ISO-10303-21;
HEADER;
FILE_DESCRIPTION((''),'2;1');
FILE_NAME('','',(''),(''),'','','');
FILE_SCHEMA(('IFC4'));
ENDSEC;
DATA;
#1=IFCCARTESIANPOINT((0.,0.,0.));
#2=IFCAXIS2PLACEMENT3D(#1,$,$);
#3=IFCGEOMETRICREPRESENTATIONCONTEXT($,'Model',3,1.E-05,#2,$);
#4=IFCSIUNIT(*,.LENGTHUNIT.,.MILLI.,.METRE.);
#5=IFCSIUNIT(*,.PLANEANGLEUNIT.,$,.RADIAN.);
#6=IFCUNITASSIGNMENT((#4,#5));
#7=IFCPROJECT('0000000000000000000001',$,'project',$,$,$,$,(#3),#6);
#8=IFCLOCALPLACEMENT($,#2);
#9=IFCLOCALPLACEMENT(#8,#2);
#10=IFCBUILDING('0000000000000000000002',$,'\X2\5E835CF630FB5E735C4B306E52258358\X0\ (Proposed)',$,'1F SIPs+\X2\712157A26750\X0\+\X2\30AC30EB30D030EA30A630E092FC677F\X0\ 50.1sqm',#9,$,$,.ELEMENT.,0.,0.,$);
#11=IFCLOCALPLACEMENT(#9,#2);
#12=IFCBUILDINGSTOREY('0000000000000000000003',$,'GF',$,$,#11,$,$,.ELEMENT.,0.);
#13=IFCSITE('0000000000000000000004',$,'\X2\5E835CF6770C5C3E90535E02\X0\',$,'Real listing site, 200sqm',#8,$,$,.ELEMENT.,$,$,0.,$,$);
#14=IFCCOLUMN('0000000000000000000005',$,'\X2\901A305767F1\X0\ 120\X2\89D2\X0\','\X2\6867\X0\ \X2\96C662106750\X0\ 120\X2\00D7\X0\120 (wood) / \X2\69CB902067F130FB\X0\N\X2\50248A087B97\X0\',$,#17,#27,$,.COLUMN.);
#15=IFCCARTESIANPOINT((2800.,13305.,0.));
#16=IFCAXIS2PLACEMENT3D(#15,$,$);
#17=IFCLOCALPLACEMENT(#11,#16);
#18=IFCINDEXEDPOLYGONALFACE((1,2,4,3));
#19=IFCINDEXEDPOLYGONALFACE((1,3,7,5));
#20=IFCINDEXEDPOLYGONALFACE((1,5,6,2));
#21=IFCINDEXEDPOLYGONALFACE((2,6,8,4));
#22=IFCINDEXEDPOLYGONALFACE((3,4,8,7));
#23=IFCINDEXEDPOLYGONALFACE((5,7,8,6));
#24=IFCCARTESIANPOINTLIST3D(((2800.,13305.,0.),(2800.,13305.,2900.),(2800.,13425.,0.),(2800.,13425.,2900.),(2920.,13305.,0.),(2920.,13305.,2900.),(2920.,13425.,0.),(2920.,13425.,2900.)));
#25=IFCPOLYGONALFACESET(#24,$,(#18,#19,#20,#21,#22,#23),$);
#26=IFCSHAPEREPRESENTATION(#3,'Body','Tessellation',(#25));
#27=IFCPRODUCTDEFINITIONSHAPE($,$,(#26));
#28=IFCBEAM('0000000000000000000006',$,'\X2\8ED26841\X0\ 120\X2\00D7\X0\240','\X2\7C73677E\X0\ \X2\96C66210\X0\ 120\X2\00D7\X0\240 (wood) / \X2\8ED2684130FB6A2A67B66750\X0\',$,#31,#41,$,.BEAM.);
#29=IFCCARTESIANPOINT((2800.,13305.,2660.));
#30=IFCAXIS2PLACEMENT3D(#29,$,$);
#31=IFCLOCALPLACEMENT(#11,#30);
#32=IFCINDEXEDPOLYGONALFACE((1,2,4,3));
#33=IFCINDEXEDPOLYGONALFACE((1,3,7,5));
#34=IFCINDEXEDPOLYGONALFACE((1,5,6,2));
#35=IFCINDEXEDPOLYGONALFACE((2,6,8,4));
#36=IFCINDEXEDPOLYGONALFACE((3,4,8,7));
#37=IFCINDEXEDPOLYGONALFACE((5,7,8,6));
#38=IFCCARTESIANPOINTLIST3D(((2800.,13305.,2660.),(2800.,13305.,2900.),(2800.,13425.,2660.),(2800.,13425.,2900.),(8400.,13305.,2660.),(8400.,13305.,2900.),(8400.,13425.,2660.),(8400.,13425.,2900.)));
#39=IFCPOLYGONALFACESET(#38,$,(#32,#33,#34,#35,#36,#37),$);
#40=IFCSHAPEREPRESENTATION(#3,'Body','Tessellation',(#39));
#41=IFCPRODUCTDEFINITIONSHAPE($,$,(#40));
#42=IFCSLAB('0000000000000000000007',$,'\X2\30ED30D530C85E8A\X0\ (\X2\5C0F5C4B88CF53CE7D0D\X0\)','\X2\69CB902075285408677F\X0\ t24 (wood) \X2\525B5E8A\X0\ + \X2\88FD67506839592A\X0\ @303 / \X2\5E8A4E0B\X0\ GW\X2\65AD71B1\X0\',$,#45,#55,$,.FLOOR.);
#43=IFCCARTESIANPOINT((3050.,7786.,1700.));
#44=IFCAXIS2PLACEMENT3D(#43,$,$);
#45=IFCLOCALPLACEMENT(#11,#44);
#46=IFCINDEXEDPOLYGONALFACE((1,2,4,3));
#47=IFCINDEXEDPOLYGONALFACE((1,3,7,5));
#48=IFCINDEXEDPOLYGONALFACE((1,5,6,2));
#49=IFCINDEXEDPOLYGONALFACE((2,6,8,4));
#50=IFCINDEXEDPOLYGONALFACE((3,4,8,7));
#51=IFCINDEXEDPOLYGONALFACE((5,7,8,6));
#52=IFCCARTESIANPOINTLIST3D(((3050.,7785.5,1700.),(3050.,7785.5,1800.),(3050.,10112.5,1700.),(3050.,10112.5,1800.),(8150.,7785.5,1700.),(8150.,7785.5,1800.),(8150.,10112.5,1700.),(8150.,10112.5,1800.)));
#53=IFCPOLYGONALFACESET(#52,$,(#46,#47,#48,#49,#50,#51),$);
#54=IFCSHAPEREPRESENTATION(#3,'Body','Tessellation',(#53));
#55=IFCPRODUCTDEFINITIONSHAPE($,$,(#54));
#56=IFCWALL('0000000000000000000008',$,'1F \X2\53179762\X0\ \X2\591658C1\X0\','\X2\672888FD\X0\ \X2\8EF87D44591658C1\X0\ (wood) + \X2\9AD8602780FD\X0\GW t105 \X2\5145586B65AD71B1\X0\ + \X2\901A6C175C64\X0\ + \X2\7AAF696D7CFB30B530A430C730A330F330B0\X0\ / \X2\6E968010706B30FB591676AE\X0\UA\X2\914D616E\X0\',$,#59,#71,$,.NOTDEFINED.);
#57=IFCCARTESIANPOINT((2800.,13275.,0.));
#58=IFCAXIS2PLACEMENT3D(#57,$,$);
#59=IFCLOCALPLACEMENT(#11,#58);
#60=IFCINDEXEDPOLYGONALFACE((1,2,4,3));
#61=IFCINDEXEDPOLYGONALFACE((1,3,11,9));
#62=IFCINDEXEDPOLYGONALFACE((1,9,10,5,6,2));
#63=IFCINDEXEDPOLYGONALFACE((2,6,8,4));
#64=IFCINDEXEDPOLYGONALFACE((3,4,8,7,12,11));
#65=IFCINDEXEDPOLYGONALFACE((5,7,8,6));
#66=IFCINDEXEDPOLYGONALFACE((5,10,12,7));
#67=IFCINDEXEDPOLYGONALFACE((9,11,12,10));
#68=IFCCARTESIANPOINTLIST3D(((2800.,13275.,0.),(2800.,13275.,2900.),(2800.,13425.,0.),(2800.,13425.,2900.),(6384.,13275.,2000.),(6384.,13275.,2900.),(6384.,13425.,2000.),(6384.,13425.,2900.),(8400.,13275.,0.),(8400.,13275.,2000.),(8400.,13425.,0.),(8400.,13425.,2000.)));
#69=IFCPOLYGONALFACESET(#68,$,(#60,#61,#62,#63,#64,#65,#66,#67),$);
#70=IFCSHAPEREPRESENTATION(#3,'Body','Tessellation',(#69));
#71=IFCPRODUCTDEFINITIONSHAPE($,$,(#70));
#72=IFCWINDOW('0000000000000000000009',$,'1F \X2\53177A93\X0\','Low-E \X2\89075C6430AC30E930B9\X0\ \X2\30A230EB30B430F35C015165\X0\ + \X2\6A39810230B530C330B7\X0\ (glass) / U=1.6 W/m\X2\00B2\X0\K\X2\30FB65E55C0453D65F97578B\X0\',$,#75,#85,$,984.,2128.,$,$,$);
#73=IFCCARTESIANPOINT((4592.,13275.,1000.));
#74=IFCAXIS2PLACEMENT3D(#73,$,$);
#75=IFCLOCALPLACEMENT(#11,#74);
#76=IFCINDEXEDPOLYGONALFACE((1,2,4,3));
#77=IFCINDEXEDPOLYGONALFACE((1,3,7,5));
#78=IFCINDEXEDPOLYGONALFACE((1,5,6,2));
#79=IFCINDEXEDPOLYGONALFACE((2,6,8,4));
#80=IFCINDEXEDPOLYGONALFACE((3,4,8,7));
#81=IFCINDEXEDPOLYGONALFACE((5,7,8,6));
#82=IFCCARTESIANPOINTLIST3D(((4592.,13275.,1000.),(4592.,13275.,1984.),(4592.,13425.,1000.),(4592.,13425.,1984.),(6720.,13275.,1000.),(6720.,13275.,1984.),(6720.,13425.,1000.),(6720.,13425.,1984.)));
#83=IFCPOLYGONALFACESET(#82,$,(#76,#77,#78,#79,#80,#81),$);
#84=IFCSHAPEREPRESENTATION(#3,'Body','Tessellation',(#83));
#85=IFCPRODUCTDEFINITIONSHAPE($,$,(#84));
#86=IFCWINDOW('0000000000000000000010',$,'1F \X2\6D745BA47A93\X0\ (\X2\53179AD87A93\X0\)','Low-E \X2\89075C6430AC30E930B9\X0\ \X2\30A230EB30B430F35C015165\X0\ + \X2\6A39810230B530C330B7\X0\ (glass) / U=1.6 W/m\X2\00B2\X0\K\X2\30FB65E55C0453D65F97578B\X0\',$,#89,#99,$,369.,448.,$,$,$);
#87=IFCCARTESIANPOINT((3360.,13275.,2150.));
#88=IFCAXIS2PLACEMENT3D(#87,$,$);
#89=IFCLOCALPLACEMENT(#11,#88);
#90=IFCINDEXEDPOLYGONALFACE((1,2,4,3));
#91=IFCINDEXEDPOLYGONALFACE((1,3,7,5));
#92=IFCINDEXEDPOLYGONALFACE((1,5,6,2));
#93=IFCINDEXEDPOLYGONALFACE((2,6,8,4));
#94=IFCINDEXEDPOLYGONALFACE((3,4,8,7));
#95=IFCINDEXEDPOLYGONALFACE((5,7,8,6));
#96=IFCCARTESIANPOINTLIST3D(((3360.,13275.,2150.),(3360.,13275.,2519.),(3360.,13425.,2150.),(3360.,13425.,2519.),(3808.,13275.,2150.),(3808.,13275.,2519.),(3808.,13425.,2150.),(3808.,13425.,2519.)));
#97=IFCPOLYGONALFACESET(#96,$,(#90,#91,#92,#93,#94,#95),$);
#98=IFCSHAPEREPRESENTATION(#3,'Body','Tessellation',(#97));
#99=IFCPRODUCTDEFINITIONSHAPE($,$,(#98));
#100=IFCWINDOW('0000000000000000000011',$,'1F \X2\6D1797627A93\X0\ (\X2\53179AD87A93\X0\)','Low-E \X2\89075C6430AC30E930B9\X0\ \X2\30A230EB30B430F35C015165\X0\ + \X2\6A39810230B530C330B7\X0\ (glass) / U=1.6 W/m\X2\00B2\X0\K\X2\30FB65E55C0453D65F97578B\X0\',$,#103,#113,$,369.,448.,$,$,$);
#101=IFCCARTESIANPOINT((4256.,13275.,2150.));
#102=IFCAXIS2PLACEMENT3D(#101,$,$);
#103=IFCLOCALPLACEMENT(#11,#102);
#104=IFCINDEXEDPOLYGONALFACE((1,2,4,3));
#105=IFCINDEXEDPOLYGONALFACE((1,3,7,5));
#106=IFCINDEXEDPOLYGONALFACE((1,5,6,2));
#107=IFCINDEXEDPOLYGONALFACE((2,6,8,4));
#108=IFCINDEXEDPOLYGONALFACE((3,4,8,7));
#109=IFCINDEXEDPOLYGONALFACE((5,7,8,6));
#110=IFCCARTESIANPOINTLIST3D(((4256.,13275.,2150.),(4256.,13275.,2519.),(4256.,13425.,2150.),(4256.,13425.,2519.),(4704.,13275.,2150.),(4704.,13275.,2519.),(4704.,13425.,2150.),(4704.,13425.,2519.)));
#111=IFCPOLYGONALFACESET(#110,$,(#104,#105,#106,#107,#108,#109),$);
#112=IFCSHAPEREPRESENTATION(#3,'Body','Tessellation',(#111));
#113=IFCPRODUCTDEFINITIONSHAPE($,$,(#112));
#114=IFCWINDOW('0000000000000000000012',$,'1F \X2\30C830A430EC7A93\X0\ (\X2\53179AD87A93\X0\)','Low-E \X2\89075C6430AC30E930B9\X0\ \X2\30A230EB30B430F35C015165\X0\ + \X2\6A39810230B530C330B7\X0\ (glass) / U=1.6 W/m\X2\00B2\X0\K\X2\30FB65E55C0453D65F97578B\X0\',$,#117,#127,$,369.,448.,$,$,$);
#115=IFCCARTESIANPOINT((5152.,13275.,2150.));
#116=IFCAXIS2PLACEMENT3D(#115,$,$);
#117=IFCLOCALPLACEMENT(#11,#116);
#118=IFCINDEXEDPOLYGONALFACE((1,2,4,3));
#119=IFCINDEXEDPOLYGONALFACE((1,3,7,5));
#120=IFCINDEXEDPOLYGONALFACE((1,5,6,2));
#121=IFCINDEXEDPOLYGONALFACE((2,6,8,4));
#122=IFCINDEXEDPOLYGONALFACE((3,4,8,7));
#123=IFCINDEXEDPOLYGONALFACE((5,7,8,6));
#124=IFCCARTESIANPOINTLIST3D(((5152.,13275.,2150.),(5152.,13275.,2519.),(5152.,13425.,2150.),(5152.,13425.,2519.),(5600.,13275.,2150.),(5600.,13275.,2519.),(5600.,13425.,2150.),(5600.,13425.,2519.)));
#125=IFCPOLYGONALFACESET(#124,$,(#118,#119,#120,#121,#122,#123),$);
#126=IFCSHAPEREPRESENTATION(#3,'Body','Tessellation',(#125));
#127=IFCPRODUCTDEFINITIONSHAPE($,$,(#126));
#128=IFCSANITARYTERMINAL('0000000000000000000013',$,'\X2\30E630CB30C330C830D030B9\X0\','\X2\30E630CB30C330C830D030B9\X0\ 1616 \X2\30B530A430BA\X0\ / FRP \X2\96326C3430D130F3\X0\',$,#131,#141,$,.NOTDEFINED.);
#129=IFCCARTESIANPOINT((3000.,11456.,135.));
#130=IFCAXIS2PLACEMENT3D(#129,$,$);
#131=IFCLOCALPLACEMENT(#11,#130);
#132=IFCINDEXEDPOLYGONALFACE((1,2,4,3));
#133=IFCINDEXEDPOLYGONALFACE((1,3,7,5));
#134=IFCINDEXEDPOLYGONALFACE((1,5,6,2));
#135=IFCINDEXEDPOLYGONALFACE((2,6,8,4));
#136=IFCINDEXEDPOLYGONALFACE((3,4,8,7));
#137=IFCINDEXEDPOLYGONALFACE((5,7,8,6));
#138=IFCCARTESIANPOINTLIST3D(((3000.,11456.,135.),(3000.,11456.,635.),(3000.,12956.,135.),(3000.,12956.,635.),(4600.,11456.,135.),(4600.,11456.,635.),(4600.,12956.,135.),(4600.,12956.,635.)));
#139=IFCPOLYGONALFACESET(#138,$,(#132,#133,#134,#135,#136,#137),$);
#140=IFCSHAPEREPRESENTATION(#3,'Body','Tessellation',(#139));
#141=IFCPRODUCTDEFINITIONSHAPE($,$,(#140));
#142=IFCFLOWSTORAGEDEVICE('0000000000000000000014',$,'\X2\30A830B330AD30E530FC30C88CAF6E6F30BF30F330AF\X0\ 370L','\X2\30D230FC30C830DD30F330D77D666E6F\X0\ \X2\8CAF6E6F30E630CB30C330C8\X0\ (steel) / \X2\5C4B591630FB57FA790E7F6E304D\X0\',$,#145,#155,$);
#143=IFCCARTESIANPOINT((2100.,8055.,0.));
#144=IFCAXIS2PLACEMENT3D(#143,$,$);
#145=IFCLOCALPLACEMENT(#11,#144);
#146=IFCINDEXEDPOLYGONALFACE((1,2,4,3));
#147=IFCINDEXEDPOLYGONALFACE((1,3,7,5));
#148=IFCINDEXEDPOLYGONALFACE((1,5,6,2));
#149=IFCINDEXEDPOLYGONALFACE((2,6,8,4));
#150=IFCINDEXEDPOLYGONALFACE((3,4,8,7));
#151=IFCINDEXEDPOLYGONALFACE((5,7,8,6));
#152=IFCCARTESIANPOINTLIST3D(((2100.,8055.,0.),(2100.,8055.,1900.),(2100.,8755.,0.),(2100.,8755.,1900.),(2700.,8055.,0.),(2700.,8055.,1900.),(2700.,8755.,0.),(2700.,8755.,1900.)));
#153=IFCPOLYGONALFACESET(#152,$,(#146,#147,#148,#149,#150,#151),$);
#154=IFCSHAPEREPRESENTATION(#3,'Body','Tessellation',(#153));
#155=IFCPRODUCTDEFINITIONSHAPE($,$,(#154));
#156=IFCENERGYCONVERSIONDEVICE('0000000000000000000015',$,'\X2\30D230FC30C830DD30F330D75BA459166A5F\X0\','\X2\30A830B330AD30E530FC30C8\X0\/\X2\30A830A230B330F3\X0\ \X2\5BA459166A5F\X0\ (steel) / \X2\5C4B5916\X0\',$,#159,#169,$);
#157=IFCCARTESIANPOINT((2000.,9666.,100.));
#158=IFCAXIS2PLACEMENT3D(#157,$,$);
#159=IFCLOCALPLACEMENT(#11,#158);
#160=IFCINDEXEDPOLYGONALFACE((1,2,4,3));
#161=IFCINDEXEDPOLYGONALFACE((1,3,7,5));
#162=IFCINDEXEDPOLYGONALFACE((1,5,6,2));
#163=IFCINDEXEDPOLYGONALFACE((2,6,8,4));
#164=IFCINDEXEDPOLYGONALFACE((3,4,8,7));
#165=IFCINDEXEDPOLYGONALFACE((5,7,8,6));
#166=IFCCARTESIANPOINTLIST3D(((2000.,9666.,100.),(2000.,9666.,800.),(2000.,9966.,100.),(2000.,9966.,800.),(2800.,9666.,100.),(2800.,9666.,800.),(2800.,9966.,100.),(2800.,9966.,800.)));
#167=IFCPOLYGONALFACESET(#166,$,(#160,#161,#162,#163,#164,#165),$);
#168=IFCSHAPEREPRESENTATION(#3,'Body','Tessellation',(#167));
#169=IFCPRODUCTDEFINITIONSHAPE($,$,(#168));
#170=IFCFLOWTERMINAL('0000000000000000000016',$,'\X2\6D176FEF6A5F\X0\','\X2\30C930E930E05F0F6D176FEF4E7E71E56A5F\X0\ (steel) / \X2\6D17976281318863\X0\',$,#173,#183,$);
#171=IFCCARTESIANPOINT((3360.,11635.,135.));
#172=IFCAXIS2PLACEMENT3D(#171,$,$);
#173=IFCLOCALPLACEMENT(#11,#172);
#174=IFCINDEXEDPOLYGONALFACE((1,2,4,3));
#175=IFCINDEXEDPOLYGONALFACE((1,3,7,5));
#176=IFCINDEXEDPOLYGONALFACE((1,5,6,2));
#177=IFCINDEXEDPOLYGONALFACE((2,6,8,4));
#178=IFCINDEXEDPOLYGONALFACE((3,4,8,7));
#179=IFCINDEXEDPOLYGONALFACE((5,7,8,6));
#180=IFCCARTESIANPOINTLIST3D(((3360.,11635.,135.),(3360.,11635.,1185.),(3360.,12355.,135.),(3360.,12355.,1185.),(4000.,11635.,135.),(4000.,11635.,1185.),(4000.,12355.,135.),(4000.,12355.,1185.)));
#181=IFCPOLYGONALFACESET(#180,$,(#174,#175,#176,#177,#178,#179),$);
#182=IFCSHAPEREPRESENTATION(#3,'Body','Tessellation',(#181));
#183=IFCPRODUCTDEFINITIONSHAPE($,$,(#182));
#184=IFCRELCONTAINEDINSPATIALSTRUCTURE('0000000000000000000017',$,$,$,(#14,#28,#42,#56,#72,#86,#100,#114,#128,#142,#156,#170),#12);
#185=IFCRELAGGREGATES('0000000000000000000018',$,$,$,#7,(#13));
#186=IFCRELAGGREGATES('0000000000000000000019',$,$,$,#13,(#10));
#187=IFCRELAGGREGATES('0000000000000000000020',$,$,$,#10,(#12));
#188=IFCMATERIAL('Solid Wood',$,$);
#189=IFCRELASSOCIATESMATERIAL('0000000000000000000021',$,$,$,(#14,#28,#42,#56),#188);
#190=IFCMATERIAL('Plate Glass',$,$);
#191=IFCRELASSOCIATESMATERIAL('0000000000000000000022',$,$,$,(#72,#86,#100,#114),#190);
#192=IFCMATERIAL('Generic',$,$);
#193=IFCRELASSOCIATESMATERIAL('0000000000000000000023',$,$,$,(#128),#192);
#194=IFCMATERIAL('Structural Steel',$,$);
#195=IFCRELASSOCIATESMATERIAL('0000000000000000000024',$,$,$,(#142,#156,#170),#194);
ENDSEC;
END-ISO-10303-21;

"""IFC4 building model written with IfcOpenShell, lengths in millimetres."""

from ifc_helpers import new_model, si_unit, frame, frame_2d, origin, place, context, project, spatial, rectangle, extrude, material, element, fill, save


model = new_model("IFC4")

# Units and contexts
model_context = context("Model", 3, precision=1e-05, world=origin())
ifc_project = project(units=[si_unit("LENGTHUNIT", "METRE", prefix="MILLI"), si_unit("PLANEANGLEUNIT", "RADIAN")], contexts=[model_context])

# Site, building, storey
site_placement = place(None, origin())
site = spatial("IfcSite", under=ifc_project, at=site_placement, Name="広島県尾道市", ObjectType="Real listing site, 200sqm", CompositionType="ELEMENT", RefElevation=0.0)
building_placement = place(site_placement, origin())
building = spatial("IfcBuilding", under=site, at=building_placement, Name="広島・平屋の別荘 (Proposed)", ObjectType="1F SIPs+無垢材+ガルバリウム鋼板 50.1sqm", CompositionType="ELEMENT", ElevationOfRefHeight=0.0, ElevationOfTerrain=0.0)
storey_placement = place(building_placement, origin())
storey = spatial("IfcBuildingStorey", under=building, at=storey_placement, Name="GF", CompositionType="ELEMENT", Elevation=0.0)

# Column
ifc_material_1 = material(Name="Solid Wood")
column_1_placement = place(storey_placement, frame((2800.0, 13305.0, 0.0)))
element("IfcColumn", 1, at=column_1_placement, inside=storey, material=ifc_material_1, Name="通し柱 120角", Description="桧 集成材 120×120 (wood) / 構造柱・N値計算", PredefinedType="COLUMN", context=model_context, shape_type="SweptSolid", body=[
    extrude(rectangle(XDim=120.0, YDim=120.0, at=frame_2d((60.0, 60.0))), frame((2800.0, 13305.0, 0.0)), (0.0, 0.0, 1.0), 2900.0),
])

# Beam
beam_1_placement = place(storey_placement, frame((2800.0, 13305.0, 2660.0)))
element("IfcBeam", 2, at=beam_1_placement, inside=storey, material=ifc_material_1, Name="軒桁 120×240", Description="米松 集成 120×240 (wood) / 軒桁・横架材", PredefinedType="BEAM", context=model_context, shape_type="SweptSolid", body=[
    extrude(rectangle(XDim=5600.0, YDim=120.0, at=frame_2d((2800.0, 60.0))), frame((2800.0, 13305.0, 2660.0)), (0.0, 0.0, 1.0), 240.0),
])

# Slab
slab_placement = place(storey_placement, frame((3050.0, 7786.0, 1700.0)))
element("IfcSlab", 3, at=slab_placement, inside=storey, material=ifc_material_1, Name="ロフト床 (小屋裏収納)", Description="構造用合板 t24 (wood) 剛床 + 製材根太 @303 / 床下 GW断熱", PredefinedType="FLOOR", context=model_context, shape_type="SweptSolid", body=[
    extrude(rectangle(XDim=5100.0, YDim=2327.0, at=frame_2d((2550.0, 1163.0))), frame((3050.0, 7786.0, 1700.0)), (0.0, 0.0, 1.0), 100.0),
])

# Wall, openings, windows
wall_1_placement = place(storey_placement, frame((2800.0, 13275.0, 0.0)))
wall_1 = element("IfcWall", 4, at=wall_1_placement, inside=storey, material=ifc_material_1, Name="1F 北面 外壁", Description="木製 軸組外壁 (wood) + 高性能GW t105 充填断熱 + 通気層 + 窯業系サイディング / 準耐火・外皮UA配慮", PredefinedType="NOTDEFINED", context=model_context, shape_type="SweptSolid", body=[
    extrude(rectangle(XDim=5600.0, YDim=150.0, at=frame_2d((2800.0, 75.0))), frame((2800.0, 13275.0, 0.0)), (0.0, 0.0, 1.0), 2900.0),
])
opening_1_placement = place(storey_placement, frame((4592.0, 13275.0, 1000.0)))
opening_1 = element("IfcOpeningElement", 5, at=opening_1_placement, cuts=wall_1, PredefinedType="NOTDEFINED", context=model_context, shape_type="SweptSolid", body=[
    extrude(rectangle(XDim=2128.0, YDim=150.0, at=frame_2d((1064.0, 75.0))), frame((4592.0, 13275.0, 1000.0)), (0.0, 0.0, 1.0), 984.0),
])
opening_2_placement = place(storey_placement, frame((3360.0, 13275.0, 2150.0)))
opening_2 = element("IfcOpeningElement", 6, at=opening_2_placement, cuts=wall_1, PredefinedType="NOTDEFINED", context=model_context, shape_type="SweptSolid", body=[
    extrude(rectangle(XDim=448.0, YDim=150.0, at=frame_2d((224.0, 75.0))), frame((3360.0, 13275.0, 2150.0)), (0.0, 0.0, 1.0), 369.0),
])
opening_3_placement = place(storey_placement, frame((4256.0, 13275.0, 2150.0)))
opening_3 = element("IfcOpeningElement", 7, at=opening_3_placement, cuts=wall_1, PredefinedType="NOTDEFINED", context=model_context, shape_type="SweptSolid", body=[
    extrude(rectangle(XDim=448.0, YDim=150.0, at=frame_2d((224.0, 75.0))), frame((4256.0, 13275.0, 2150.0)), (0.0, 0.0, 1.0), 369.0),
])
opening_4_placement = place(storey_placement, frame((5152.0, 13275.0, 2150.0)))
opening_4 = element("IfcOpeningElement", 8, at=opening_4_placement, cuts=wall_1, PredefinedType="NOTDEFINED", context=model_context, shape_type="SweptSolid", body=[
    extrude(rectangle(XDim=448.0, YDim=150.0, at=frame_2d((224.0, 75.0))), frame((5152.0, 13275.0, 2150.0)), (0.0, 0.0, 1.0), 369.0),
])
ifc_material_2 = material(Name="Plate Glass")
window_1_placement = place(storey_placement, frame((4592.0, 13275.0, 1000.0)))
window_1 = element("IfcWindow", 9, at=window_1_placement, inside=storey, material=ifc_material_2, Name="1F 北窓", Description="Low-E 複層ガラス アルゴン封入 + 樹脂サッシ (glass) / U=1.6 W/m²K・日射取得型", OverallHeight=984.0, OverallWidth=2128.0, context=model_context, shape_type="SweptSolid", body=[
    extrude(rectangle(XDim=2128.0, YDim=150.0, at=frame_2d((1064.0, 75.0))), frame((4592.0, 13275.0, 1000.0)), (0.0, 0.0, 1.0), 984.0),
])
fill(opening_1, window_1)
window_2_placement = place(storey_placement, frame((3360.0, 13275.0, 2150.0)))
window_2 = element("IfcWindow", 10, at=window_2_placement, inside=storey, material=ifc_material_2, Name="1F 浴室窓 (北高窓)", Description="Low-E 複層ガラス アルゴン封入 + 樹脂サッシ (glass) / U=1.6 W/m²K・日射取得型", OverallHeight=369.0, OverallWidth=448.0, context=model_context, shape_type="SweptSolid", body=[
    extrude(rectangle(XDim=448.0, YDim=150.0, at=frame_2d((224.0, 75.0))), frame((3360.0, 13275.0, 2150.0)), (0.0, 0.0, 1.0), 369.0),
])
fill(opening_2, window_2)
window_3_placement = place(storey_placement, frame((4256.0, 13275.0, 2150.0)))
window_3 = element("IfcWindow", 11, at=window_3_placement, inside=storey, material=ifc_material_2, Name="1F 洗面窓 (北高窓)", Description="Low-E 複層ガラス アルゴン封入 + 樹脂サッシ (glass) / U=1.6 W/m²K・日射取得型", OverallHeight=369.0, OverallWidth=448.0, context=model_context, shape_type="SweptSolid", body=[
    extrude(rectangle(XDim=448.0, YDim=150.0, at=frame_2d((224.0, 75.0))), frame((4256.0, 13275.0, 2150.0)), (0.0, 0.0, 1.0), 369.0),
])
fill(opening_3, window_3)
window_4_placement = place(storey_placement, frame((5152.0, 13275.0, 2150.0)))
window_4 = element("IfcWindow", 12, at=window_4_placement, inside=storey, material=ifc_material_2, Name="1F トイレ窓 (北高窓)", Description="Low-E 複層ガラス アルゴン封入 + 樹脂サッシ (glass) / U=1.6 W/m²K・日射取得型", OverallHeight=369.0, OverallWidth=448.0, context=model_context, shape_type="SweptSolid", body=[
    extrude(rectangle(XDim=448.0, YDim=150.0, at=frame_2d((224.0, 75.0))), frame((5152.0, 13275.0, 2150.0)), (0.0, 0.0, 1.0), 369.0),
])
fill(opening_4, window_4)

# Sanitary terminal
ifc_material_3 = material(Name="Generic")
sanitary_terminal_placement = place(storey_placement, frame((3000.0, 11456.0, 135.0)))
element("IfcSanitaryTerminal", 13, at=sanitary_terminal_placement, inside=storey, material=ifc_material_3, Name="ユニットバス", Description="ユニットバス 1616 サイズ / FRP 防水パン", PredefinedType="NOTDEFINED", context=model_context, shape_type="SweptSolid", body=[
    extrude(rectangle(XDim=1600.0, YDim=1500.0, at=frame_2d((800.0, 750.0))), frame((3000.0, 11456.0, 135.0)), (0.0, 0.0, 1.0), 500.0),
])

# Flow storage device
ifc_material_4 = material(Name="Structural Steel")
flow_storage_device_placement = place(storey_placement, frame((2100.0, 8055.0, 0.0)))
element("IfcFlowStorageDevice", 14, at=flow_storage_device_placement, inside=storey, material=ifc_material_4, Name="エコキュート貯湯タンク 370L", Description="ヒートポンプ給湯 貯湯ユニット (steel) / 屋外・基礎置き", context=model_context, shape_type="SweptSolid", body=[
    extrude(rectangle(XDim=600.0, YDim=700.0, at=frame_2d((300.0, 350.0))), frame((2100.0, 8055.0, 0.0)), (0.0, 0.0, 1.0), 1900.0),
])

# Energy conversion device
energy_conversion_device_placement = place(storey_placement, frame((2000.0, 9666.0, 100.0)))
element("IfcEnergyConversionDevice", 15, at=energy_conversion_device_placement, inside=storey, material=ifc_material_4, Name="ヒートポンプ室外機", Description="エコキュート/エアコン 室外機 (steel) / 屋外", context=model_context, shape_type="SweptSolid", body=[
    extrude(rectangle(XDim=800.0, YDim=300.0, at=frame_2d((400.0, 150.0))), frame((2000.0, 9666.0, 100.0)), (0.0, 0.0, 1.0), 700.0),
])

# Flow terminal
flow_terminal_placement = place(storey_placement, frame((3360.0, 11635.0, 135.0)))
element("IfcFlowTerminal", 16, at=flow_terminal_placement, inside=storey, material=ifc_material_4, Name="洗濯機", Description="ドラム式洗濯乾燥機 (steel) / 洗面脱衣", context=model_context, shape_type="SweptSolid", body=[
    extrude(rectangle(XDim=640.0, YDim=720.0, at=frame_2d((320.0, 360.0))), frame((3360.0, 11635.0, 135.0)), (0.0, 0.0, 1.0), 1050.0),
])

save(model, "model.ifc")
